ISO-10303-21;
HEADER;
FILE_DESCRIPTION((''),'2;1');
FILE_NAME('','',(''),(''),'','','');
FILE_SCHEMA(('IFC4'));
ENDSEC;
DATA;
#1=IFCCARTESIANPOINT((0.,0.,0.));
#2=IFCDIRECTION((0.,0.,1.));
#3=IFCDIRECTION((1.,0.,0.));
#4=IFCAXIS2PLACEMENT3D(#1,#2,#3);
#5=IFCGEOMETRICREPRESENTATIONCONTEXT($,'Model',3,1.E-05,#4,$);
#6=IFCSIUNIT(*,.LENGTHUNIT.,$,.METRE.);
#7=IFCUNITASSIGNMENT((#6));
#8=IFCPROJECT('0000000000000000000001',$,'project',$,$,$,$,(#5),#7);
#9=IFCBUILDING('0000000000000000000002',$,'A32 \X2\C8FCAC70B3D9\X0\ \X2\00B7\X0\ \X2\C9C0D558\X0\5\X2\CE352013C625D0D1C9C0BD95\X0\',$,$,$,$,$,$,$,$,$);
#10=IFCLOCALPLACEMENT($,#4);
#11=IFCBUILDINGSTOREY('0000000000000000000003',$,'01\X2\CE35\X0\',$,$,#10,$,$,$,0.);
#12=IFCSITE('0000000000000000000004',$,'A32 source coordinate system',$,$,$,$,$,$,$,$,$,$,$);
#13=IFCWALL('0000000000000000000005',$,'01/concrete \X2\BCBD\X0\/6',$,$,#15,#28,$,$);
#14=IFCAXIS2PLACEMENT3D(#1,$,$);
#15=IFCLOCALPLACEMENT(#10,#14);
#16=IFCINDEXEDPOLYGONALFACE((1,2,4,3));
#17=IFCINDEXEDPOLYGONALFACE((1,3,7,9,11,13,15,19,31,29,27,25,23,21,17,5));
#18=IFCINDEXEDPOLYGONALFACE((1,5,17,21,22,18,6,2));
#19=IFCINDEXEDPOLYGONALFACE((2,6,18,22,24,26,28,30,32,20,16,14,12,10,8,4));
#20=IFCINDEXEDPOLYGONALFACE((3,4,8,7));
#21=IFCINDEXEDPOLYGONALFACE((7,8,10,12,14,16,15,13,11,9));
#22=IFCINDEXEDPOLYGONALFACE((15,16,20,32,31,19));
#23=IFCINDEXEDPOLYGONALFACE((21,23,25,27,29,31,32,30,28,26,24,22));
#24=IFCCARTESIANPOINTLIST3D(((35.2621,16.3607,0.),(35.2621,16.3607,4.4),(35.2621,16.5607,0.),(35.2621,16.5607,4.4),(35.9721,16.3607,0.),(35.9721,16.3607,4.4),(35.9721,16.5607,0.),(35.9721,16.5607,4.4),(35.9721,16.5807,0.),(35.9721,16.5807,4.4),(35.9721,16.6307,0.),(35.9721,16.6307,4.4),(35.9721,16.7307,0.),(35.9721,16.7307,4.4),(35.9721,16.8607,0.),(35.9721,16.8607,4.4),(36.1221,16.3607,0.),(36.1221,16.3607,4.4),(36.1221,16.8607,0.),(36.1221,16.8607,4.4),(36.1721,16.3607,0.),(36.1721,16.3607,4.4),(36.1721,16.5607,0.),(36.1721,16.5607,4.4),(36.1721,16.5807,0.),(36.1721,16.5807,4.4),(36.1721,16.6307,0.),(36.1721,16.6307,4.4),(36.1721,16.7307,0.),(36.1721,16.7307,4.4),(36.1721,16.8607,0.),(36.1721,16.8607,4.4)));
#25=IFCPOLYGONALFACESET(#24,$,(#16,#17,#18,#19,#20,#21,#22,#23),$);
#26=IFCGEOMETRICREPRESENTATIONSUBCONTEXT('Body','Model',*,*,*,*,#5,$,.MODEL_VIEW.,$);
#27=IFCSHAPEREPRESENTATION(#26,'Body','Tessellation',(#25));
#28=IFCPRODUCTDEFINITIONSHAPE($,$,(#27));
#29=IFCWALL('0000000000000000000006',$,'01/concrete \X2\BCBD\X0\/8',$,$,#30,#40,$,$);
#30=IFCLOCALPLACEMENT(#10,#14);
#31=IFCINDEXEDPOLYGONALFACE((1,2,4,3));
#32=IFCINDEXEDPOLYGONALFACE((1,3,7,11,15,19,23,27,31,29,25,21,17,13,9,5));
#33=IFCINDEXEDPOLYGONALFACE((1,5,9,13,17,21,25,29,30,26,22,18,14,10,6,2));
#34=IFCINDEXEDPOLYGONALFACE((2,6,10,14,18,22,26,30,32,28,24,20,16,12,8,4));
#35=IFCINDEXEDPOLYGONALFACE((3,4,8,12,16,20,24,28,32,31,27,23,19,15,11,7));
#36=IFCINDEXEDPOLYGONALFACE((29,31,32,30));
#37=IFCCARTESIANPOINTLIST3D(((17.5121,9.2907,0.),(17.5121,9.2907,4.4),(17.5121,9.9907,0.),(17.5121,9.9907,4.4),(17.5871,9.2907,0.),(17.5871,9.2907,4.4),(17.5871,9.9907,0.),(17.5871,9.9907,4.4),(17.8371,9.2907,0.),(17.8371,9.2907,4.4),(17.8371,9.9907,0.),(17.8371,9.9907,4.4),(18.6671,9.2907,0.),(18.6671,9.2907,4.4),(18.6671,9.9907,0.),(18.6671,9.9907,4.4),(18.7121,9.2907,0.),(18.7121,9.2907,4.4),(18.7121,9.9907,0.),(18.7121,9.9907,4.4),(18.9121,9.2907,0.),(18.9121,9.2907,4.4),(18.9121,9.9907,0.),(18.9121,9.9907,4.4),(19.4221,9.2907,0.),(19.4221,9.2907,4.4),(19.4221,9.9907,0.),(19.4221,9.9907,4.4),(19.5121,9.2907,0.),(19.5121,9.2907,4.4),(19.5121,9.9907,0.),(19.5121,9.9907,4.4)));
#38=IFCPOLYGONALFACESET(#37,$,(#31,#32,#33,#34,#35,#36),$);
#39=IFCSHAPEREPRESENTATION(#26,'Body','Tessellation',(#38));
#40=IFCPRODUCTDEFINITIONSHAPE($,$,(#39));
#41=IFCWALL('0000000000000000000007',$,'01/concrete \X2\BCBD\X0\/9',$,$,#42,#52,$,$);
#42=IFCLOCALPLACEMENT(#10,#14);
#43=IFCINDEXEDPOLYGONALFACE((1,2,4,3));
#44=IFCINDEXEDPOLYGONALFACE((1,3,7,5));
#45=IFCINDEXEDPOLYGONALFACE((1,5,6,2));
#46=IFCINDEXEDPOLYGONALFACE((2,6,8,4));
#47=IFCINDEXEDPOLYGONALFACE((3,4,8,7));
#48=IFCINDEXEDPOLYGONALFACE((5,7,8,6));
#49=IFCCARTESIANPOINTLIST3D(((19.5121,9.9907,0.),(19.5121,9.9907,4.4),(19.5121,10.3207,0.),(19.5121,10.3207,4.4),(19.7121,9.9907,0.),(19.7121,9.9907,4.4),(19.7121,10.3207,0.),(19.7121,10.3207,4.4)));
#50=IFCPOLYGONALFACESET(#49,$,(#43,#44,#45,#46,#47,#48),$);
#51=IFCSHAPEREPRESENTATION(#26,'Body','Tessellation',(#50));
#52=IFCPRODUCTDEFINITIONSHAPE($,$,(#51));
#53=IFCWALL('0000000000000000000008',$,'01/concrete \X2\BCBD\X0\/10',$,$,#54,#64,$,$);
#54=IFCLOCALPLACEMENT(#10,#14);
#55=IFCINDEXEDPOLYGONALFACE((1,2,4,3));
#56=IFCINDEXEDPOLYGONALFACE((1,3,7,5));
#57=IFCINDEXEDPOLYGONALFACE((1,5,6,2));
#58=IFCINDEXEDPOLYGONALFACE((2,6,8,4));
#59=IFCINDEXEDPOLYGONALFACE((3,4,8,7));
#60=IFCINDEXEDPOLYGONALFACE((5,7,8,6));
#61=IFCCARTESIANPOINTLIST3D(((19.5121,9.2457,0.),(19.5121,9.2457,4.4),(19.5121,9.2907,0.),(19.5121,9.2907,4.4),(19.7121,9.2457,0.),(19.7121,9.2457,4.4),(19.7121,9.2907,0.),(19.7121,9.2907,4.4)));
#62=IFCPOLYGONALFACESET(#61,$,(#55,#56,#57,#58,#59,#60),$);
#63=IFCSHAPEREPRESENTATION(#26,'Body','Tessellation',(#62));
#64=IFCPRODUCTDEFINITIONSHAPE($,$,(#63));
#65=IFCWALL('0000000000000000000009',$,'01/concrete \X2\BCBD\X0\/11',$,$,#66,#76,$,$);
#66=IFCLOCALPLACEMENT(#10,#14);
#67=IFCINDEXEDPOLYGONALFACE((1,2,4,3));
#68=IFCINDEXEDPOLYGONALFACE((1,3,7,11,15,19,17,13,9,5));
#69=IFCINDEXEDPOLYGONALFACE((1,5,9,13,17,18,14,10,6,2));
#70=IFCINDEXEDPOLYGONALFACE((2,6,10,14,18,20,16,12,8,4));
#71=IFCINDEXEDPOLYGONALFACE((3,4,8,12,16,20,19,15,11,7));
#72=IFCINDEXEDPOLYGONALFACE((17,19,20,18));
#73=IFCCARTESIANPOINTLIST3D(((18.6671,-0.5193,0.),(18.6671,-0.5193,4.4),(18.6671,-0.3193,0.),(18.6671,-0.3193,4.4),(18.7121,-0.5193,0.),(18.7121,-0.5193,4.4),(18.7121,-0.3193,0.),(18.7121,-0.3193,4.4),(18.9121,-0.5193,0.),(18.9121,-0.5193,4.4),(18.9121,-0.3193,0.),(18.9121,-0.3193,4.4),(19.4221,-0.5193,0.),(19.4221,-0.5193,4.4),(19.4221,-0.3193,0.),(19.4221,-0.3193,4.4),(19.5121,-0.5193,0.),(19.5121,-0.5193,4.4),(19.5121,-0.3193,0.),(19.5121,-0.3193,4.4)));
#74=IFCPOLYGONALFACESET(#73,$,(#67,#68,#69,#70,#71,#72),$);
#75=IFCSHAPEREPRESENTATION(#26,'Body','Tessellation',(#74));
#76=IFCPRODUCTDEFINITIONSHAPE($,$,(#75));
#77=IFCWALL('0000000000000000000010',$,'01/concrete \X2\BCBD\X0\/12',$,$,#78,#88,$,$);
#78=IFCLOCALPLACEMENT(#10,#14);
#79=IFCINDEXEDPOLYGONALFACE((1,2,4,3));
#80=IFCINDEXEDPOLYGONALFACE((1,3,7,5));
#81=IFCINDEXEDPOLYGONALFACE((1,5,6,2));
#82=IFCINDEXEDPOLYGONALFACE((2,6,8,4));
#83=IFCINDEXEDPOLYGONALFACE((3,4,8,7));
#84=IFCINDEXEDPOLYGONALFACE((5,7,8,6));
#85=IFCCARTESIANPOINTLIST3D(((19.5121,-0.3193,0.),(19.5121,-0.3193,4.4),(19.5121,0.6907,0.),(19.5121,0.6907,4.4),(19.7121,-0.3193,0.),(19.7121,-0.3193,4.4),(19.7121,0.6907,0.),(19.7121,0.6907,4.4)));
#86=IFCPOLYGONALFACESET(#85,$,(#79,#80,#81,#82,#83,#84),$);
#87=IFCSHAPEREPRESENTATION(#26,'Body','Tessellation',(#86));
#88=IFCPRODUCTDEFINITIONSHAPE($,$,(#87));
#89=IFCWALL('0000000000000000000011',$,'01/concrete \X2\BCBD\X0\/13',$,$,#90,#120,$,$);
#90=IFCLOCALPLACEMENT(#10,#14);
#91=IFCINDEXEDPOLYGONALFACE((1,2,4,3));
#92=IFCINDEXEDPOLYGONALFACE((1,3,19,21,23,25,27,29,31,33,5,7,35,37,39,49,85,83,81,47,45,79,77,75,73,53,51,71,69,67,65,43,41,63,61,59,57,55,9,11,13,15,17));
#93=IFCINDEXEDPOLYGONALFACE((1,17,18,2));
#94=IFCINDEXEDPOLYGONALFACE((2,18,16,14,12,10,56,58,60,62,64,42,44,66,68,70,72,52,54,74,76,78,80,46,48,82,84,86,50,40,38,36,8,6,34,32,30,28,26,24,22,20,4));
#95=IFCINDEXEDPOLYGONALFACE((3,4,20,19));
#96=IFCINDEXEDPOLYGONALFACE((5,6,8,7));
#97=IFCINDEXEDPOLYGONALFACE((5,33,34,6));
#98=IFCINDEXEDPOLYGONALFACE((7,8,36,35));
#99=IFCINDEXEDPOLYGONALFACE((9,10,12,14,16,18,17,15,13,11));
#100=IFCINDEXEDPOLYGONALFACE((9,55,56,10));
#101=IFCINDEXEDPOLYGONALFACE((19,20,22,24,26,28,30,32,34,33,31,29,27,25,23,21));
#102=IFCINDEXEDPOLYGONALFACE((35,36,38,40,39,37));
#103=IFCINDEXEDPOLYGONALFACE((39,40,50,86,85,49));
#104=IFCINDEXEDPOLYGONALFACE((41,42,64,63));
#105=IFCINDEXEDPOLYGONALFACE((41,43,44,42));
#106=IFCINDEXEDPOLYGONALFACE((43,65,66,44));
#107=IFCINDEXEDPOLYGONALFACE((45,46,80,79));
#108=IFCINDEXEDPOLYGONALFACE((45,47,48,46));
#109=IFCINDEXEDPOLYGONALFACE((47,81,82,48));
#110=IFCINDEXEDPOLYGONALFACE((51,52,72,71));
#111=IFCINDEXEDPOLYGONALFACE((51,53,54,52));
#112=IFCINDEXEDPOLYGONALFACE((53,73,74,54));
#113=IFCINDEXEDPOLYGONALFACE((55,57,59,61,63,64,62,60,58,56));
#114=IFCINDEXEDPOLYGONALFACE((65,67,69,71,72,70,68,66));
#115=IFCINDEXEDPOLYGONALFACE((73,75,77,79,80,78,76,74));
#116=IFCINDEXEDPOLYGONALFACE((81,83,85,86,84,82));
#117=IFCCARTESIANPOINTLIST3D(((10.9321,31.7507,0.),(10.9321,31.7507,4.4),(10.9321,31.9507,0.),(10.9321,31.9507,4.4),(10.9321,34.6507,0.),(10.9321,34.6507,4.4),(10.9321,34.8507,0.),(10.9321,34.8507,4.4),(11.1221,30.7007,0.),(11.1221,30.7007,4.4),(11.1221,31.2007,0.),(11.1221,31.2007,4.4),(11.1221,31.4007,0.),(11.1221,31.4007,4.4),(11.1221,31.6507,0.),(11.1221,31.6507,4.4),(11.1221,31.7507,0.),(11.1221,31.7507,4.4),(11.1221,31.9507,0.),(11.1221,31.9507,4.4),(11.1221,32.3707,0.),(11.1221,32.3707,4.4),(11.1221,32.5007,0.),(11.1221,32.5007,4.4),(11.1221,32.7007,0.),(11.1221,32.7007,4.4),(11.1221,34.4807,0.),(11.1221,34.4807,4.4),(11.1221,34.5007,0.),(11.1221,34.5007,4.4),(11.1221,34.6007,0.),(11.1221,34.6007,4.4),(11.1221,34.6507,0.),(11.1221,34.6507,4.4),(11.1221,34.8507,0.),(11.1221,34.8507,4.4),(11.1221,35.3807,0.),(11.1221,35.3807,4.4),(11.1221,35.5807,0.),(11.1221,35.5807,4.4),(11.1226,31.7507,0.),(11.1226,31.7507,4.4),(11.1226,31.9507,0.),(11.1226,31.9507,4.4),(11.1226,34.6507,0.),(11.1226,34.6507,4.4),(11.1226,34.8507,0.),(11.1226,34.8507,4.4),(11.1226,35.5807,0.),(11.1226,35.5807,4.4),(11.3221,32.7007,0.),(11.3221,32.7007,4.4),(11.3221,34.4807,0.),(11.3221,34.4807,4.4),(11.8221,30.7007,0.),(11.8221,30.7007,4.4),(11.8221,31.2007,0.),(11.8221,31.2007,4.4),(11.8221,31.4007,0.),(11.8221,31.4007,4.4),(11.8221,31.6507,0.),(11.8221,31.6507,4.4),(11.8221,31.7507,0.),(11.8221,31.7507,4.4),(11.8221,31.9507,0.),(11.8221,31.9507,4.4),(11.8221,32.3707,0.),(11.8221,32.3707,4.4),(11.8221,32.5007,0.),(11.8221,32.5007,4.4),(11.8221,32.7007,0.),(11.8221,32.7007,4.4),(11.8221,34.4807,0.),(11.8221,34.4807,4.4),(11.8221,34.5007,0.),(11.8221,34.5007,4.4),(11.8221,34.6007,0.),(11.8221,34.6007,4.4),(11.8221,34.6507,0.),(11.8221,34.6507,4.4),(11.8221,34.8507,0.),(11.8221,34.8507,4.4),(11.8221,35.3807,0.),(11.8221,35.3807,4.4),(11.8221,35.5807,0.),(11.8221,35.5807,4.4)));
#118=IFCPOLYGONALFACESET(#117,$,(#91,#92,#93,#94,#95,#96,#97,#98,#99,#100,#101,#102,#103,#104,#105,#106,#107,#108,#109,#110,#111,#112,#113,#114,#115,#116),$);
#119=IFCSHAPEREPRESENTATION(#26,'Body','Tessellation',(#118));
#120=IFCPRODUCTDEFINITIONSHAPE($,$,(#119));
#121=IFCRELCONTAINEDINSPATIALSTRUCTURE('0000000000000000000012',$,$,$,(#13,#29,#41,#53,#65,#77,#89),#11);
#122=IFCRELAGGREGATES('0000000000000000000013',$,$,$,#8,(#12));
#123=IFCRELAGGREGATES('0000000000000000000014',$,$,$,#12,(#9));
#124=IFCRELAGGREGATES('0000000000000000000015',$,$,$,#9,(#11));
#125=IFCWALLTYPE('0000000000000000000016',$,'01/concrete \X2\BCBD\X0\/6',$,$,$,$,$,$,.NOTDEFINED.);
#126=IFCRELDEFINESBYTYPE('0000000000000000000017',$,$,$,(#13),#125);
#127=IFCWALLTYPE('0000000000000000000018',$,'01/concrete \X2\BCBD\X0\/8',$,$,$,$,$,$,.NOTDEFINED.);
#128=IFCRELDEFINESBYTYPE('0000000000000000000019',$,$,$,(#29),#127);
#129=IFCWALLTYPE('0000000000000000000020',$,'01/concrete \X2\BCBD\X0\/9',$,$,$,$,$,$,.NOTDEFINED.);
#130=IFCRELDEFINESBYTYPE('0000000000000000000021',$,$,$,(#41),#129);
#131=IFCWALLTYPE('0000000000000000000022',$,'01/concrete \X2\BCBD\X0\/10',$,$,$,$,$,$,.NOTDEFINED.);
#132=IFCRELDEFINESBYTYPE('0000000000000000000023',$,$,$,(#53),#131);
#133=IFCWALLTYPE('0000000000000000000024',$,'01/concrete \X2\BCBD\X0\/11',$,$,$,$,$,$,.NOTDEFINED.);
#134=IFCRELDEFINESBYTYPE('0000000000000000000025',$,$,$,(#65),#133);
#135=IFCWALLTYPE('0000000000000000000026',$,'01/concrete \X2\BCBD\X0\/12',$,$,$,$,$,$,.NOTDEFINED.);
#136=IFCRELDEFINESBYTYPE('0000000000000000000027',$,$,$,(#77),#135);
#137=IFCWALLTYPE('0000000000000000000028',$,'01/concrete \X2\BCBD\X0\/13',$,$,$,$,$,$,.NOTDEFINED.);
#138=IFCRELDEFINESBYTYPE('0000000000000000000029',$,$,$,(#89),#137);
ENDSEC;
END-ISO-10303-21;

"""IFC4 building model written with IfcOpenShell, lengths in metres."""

from ifc_helpers import new_model, si_unit, origin, origin_with_axes, place, context, subcontext, project, spatial, polyline, outline, extrude, source, transform, mapped, type_object, type_shapes, element, save


model = new_model("IFC4")

# Units and contexts
model_context = context("Model", 3, precision=1e-05, world=origin_with_axes())
body_context = subcontext(model_context, "Body", "Model", "MODEL_VIEW")
ifc_project = project(units=[si_unit("LENGTHUNIT", "METRE")], contexts=[model_context])

# Site, building, storey
site = spatial("IfcSite", under=ifc_project, Name="A32 source coordinate system")
building = spatial("IfcBuilding", under=site, Name="A32 주거동 · 지하5층–옥탑지붕")
storey_placement = place(None, origin_with_axes())
storey = spatial("IfcBuildingStorey", under=building, at=storey_placement, Name="01층", Elevation=0.0)

# Walls
wall_type_1 = type_object("IfcWallType", Name="01/concrete 벽/6", PredefinedType="NOTDEFINED")
shared_shape_1 = source(origin(), body_context, "Body", "SweptSolid", [
    extrude(outline(polyline([(36.1721, 16.7307), (36.1721, 16.6307), (36.1721, 16.5807), (36.1721, 16.5607), (36.1721, 16.3607), (36.1221, 16.3607), (35.9721, 16.3607), (35.2621, 16.3607), (35.2621, 16.5607), (35.9721, 16.5607), (35.9721, 16.5807), (35.9721, 16.6307), (35.9721, 16.7307), (35.9721, 16.8607), (36.1221, 16.8607), (36.1721, 16.8607), (36.1721, 16.7307)])), origin(), (0.0, 0.0, 1.0), 4.4),
])
type_shapes(wall_type_1, [shared_shape_1])
wall_1_placement = place(storey_placement, origin_with_axes())
element("IfcWall", 1, at=wall_1_placement, inside=storey, type_object=wall_type_1, Name="01/concrete 벽/6", context=body_context, shape_type="MappedRepresentation", body=[
    mapped(shared_shape_1, transform((0.0, 0.0, 0.0), scale=1.0)),
])
wall_type_2 = type_object("IfcWallType", Name="01/concrete 벽/8", PredefinedType="NOTDEFINED")
shared_shape_2 = source(origin(), body_context, "Body", "SweptSolid", [
    extrude(outline(polyline([(17.5121, 9.9907), (17.5871, 9.9907), (17.8371, 9.9907), (18.6671, 9.9907), (18.7121, 9.9907), (18.9121, 9.9907), (19.4221, 9.9907), (19.5121, 9.9907), (19.5121, 9.2907), (19.4221, 9.2907), (18.9121, 9.2907), (18.7121, 9.2907), (18.6671, 9.2907), (17.8371, 9.2907), (17.5871, 9.2907), (17.5121, 9.2907), (17.5121, 9.9907)])), origin(), (0.0, 0.0, 1.0), 4.4),
])
type_shapes(wall_type_2, [shared_shape_2])
wall_2_placement = place(storey_placement, origin_with_axes())
element("IfcWall", 2, at=wall_2_placement, inside=storey, type_object=wall_type_2, Name="01/concrete 벽/8", context=body_context, shape_type="MappedRepresentation", body=[
    mapped(shared_shape_2, transform((0.0, 0.0, 0.0), scale=1.0)),
])
wall_type_3 = type_object("IfcWallType", Name="01/concrete 벽/9", PredefinedType="NOTDEFINED")
shared_shape_3 = source(origin(), body_context, "Body", "SweptSolid", [
    extrude(outline(polyline([(19.7121, 9.9907), (19.5121, 9.9907), (19.5121, 10.3207), (19.7121, 10.3207), (19.7121, 9.9907)])), origin(), (0.0, 0.0, 1.0), 4.4),
])
type_shapes(wall_type_3, [shared_shape_3])
wall_3_placement = place(storey_placement, origin_with_axes())
element("IfcWall", 3, at=wall_3_placement, inside=storey, type_object=wall_type_3, Name="01/concrete 벽/9", context=body_context, shape_type="MappedRepresentation", body=[
    mapped(shared_shape_3, transform((0.0, 0.0, 0.0), scale=1.0)),
])
wall_type_4 = type_object("IfcWallType", Name="01/concrete 벽/10", PredefinedType="NOTDEFINED")
shared_shape_4 = source(origin(), body_context, "Body", "SweptSolid", [
    extrude(outline(polyline([(19.5121, 9.2457), (19.5121, 9.2907), (19.7121, 9.2907), (19.7121, 9.2457), (19.5121, 9.2457)])), origin(), (0.0, 0.0, 1.0), 4.4),
])
type_shapes(wall_type_4, [shared_shape_4])
wall_4_placement = place(storey_placement, origin_with_axes())
element("IfcWall", 4, at=wall_4_placement, inside=storey, type_object=wall_type_4, Name="01/concrete 벽/10", context=body_context, shape_type="MappedRepresentation", body=[
    mapped(shared_shape_4, transform((0.0, 0.0, 0.0), scale=1.0)),
])
wall_type_5 = type_object("IfcWallType", Name="01/concrete 벽/11", PredefinedType="NOTDEFINED")
shared_shape_5 = source(origin(), body_context, "Body", "SweptSolid", [
    extrude(outline(polyline([(19.5121, -0.5193), (19.4221, -0.5193), (18.9121, -0.5193), (18.7121, -0.5193), (18.6671, -0.5193), (18.6671, -0.3193), (18.7121, -0.3193), (18.9121, -0.3193), (19.4221, -0.3193), (19.5121, -0.3193), (19.5121, -0.5193)])), origin(), (0.0, 0.0, 1.0), 4.4),
])
type_shapes(wall_type_5, [shared_shape_5])
wall_5_placement = place(storey_placement, origin_with_axes())
element("IfcWall", 5, at=wall_5_placement, inside=storey, type_object=wall_type_5, Name="01/concrete 벽/11", context=body_context, shape_type="MappedRepresentation", body=[
    mapped(shared_shape_5, transform((0.0, 0.0, 0.0), scale=1.0)),
])
wall_type_6 = type_object("IfcWallType", Name="01/concrete 벽/12", PredefinedType="NOTDEFINED")
shared_shape_6 = source(origin(), body_context, "Body", "SweptSolid", [
    extrude(outline(polyline([(19.7121, -0.3193), (19.5121, -0.3193), (19.5121, 0.6907), (19.7121, 0.6907), (19.7121, -0.3193)])), origin(), (0.0, 0.0, 1.0), 4.4),
])
type_shapes(wall_type_6, [shared_shape_6])
wall_6_placement = place(storey_placement, origin_with_axes())
element("IfcWall", 6, at=wall_6_placement, inside=storey, type_object=wall_type_6, Name="01/concrete 벽/12", context=body_context, shape_type="MappedRepresentation", body=[
    mapped(shared_shape_6, transform((0.0, 0.0, 0.0), scale=1.0)),
])
wall_type_7 = type_object("IfcWallType", Name="01/concrete 벽/13", PredefinedType="NOTDEFINED")
shared_shape_7 = source(origin(), body_context, "Body", "SweptSolid", [
    extrude(outline(polyline([(11.1221, 34.4807), (11.1221, 34.5007), (11.1221, 34.6007), (11.1221, 34.6507), (10.9321, 34.6507), (10.9321, 34.8507), (11.1221, 34.8507), (11.1221, 35.3807), (11.1221, 35.5807), (11.1226, 35.5807), (11.8221, 35.5807), (11.8221, 35.3807), (11.8221, 34.8507), (11.1226, 34.8507), (11.1226, 34.6507), (11.8221, 34.6507), (11.8221, 34.6007), (11.8221, 34.5007), (11.8221, 34.4807), (11.3221, 34.4807), (11.3221, 32.7007), (11.8221, 32.7007), (11.8221, 32.5007), (11.8221, 32.3707), (11.8221, 31.9507), (11.1226, 31.9507), (11.1226, 31.7507), (11.8221, 31.7507), (11.8221, 31.6507), (11.8221, 31.4007), (11.8221, 31.2007), (11.8221, 30.7007), (11.1221, 30.7007), (11.1221, 31.2007), (11.1221, 31.4007), (11.1221, 31.6507), (11.1221, 31.7507), (10.9321, 31.7507), (10.9321, 31.9507), (11.1221, 31.9507), (11.1221, 32.3707), (11.1221, 32.5007), (11.1221, 32.7007), (11.1221, 34.4807)])), origin(), (0.0, 0.0, 1.0), 4.4),
])
type_shapes(wall_type_7, [shared_shape_7])
wall_7_placement = place(storey_placement, origin_with_axes())
element("IfcWall", 7, at=wall_7_placement, inside=storey, type_object=wall_type_7, Name="01/concrete 벽/13", context=body_context, shape_type="MappedRepresentation", body=[
    mapped(shared_shape_7, transform((0.0, 0.0, 0.0), scale=1.0)),
])

save(model, "model.ifc")
